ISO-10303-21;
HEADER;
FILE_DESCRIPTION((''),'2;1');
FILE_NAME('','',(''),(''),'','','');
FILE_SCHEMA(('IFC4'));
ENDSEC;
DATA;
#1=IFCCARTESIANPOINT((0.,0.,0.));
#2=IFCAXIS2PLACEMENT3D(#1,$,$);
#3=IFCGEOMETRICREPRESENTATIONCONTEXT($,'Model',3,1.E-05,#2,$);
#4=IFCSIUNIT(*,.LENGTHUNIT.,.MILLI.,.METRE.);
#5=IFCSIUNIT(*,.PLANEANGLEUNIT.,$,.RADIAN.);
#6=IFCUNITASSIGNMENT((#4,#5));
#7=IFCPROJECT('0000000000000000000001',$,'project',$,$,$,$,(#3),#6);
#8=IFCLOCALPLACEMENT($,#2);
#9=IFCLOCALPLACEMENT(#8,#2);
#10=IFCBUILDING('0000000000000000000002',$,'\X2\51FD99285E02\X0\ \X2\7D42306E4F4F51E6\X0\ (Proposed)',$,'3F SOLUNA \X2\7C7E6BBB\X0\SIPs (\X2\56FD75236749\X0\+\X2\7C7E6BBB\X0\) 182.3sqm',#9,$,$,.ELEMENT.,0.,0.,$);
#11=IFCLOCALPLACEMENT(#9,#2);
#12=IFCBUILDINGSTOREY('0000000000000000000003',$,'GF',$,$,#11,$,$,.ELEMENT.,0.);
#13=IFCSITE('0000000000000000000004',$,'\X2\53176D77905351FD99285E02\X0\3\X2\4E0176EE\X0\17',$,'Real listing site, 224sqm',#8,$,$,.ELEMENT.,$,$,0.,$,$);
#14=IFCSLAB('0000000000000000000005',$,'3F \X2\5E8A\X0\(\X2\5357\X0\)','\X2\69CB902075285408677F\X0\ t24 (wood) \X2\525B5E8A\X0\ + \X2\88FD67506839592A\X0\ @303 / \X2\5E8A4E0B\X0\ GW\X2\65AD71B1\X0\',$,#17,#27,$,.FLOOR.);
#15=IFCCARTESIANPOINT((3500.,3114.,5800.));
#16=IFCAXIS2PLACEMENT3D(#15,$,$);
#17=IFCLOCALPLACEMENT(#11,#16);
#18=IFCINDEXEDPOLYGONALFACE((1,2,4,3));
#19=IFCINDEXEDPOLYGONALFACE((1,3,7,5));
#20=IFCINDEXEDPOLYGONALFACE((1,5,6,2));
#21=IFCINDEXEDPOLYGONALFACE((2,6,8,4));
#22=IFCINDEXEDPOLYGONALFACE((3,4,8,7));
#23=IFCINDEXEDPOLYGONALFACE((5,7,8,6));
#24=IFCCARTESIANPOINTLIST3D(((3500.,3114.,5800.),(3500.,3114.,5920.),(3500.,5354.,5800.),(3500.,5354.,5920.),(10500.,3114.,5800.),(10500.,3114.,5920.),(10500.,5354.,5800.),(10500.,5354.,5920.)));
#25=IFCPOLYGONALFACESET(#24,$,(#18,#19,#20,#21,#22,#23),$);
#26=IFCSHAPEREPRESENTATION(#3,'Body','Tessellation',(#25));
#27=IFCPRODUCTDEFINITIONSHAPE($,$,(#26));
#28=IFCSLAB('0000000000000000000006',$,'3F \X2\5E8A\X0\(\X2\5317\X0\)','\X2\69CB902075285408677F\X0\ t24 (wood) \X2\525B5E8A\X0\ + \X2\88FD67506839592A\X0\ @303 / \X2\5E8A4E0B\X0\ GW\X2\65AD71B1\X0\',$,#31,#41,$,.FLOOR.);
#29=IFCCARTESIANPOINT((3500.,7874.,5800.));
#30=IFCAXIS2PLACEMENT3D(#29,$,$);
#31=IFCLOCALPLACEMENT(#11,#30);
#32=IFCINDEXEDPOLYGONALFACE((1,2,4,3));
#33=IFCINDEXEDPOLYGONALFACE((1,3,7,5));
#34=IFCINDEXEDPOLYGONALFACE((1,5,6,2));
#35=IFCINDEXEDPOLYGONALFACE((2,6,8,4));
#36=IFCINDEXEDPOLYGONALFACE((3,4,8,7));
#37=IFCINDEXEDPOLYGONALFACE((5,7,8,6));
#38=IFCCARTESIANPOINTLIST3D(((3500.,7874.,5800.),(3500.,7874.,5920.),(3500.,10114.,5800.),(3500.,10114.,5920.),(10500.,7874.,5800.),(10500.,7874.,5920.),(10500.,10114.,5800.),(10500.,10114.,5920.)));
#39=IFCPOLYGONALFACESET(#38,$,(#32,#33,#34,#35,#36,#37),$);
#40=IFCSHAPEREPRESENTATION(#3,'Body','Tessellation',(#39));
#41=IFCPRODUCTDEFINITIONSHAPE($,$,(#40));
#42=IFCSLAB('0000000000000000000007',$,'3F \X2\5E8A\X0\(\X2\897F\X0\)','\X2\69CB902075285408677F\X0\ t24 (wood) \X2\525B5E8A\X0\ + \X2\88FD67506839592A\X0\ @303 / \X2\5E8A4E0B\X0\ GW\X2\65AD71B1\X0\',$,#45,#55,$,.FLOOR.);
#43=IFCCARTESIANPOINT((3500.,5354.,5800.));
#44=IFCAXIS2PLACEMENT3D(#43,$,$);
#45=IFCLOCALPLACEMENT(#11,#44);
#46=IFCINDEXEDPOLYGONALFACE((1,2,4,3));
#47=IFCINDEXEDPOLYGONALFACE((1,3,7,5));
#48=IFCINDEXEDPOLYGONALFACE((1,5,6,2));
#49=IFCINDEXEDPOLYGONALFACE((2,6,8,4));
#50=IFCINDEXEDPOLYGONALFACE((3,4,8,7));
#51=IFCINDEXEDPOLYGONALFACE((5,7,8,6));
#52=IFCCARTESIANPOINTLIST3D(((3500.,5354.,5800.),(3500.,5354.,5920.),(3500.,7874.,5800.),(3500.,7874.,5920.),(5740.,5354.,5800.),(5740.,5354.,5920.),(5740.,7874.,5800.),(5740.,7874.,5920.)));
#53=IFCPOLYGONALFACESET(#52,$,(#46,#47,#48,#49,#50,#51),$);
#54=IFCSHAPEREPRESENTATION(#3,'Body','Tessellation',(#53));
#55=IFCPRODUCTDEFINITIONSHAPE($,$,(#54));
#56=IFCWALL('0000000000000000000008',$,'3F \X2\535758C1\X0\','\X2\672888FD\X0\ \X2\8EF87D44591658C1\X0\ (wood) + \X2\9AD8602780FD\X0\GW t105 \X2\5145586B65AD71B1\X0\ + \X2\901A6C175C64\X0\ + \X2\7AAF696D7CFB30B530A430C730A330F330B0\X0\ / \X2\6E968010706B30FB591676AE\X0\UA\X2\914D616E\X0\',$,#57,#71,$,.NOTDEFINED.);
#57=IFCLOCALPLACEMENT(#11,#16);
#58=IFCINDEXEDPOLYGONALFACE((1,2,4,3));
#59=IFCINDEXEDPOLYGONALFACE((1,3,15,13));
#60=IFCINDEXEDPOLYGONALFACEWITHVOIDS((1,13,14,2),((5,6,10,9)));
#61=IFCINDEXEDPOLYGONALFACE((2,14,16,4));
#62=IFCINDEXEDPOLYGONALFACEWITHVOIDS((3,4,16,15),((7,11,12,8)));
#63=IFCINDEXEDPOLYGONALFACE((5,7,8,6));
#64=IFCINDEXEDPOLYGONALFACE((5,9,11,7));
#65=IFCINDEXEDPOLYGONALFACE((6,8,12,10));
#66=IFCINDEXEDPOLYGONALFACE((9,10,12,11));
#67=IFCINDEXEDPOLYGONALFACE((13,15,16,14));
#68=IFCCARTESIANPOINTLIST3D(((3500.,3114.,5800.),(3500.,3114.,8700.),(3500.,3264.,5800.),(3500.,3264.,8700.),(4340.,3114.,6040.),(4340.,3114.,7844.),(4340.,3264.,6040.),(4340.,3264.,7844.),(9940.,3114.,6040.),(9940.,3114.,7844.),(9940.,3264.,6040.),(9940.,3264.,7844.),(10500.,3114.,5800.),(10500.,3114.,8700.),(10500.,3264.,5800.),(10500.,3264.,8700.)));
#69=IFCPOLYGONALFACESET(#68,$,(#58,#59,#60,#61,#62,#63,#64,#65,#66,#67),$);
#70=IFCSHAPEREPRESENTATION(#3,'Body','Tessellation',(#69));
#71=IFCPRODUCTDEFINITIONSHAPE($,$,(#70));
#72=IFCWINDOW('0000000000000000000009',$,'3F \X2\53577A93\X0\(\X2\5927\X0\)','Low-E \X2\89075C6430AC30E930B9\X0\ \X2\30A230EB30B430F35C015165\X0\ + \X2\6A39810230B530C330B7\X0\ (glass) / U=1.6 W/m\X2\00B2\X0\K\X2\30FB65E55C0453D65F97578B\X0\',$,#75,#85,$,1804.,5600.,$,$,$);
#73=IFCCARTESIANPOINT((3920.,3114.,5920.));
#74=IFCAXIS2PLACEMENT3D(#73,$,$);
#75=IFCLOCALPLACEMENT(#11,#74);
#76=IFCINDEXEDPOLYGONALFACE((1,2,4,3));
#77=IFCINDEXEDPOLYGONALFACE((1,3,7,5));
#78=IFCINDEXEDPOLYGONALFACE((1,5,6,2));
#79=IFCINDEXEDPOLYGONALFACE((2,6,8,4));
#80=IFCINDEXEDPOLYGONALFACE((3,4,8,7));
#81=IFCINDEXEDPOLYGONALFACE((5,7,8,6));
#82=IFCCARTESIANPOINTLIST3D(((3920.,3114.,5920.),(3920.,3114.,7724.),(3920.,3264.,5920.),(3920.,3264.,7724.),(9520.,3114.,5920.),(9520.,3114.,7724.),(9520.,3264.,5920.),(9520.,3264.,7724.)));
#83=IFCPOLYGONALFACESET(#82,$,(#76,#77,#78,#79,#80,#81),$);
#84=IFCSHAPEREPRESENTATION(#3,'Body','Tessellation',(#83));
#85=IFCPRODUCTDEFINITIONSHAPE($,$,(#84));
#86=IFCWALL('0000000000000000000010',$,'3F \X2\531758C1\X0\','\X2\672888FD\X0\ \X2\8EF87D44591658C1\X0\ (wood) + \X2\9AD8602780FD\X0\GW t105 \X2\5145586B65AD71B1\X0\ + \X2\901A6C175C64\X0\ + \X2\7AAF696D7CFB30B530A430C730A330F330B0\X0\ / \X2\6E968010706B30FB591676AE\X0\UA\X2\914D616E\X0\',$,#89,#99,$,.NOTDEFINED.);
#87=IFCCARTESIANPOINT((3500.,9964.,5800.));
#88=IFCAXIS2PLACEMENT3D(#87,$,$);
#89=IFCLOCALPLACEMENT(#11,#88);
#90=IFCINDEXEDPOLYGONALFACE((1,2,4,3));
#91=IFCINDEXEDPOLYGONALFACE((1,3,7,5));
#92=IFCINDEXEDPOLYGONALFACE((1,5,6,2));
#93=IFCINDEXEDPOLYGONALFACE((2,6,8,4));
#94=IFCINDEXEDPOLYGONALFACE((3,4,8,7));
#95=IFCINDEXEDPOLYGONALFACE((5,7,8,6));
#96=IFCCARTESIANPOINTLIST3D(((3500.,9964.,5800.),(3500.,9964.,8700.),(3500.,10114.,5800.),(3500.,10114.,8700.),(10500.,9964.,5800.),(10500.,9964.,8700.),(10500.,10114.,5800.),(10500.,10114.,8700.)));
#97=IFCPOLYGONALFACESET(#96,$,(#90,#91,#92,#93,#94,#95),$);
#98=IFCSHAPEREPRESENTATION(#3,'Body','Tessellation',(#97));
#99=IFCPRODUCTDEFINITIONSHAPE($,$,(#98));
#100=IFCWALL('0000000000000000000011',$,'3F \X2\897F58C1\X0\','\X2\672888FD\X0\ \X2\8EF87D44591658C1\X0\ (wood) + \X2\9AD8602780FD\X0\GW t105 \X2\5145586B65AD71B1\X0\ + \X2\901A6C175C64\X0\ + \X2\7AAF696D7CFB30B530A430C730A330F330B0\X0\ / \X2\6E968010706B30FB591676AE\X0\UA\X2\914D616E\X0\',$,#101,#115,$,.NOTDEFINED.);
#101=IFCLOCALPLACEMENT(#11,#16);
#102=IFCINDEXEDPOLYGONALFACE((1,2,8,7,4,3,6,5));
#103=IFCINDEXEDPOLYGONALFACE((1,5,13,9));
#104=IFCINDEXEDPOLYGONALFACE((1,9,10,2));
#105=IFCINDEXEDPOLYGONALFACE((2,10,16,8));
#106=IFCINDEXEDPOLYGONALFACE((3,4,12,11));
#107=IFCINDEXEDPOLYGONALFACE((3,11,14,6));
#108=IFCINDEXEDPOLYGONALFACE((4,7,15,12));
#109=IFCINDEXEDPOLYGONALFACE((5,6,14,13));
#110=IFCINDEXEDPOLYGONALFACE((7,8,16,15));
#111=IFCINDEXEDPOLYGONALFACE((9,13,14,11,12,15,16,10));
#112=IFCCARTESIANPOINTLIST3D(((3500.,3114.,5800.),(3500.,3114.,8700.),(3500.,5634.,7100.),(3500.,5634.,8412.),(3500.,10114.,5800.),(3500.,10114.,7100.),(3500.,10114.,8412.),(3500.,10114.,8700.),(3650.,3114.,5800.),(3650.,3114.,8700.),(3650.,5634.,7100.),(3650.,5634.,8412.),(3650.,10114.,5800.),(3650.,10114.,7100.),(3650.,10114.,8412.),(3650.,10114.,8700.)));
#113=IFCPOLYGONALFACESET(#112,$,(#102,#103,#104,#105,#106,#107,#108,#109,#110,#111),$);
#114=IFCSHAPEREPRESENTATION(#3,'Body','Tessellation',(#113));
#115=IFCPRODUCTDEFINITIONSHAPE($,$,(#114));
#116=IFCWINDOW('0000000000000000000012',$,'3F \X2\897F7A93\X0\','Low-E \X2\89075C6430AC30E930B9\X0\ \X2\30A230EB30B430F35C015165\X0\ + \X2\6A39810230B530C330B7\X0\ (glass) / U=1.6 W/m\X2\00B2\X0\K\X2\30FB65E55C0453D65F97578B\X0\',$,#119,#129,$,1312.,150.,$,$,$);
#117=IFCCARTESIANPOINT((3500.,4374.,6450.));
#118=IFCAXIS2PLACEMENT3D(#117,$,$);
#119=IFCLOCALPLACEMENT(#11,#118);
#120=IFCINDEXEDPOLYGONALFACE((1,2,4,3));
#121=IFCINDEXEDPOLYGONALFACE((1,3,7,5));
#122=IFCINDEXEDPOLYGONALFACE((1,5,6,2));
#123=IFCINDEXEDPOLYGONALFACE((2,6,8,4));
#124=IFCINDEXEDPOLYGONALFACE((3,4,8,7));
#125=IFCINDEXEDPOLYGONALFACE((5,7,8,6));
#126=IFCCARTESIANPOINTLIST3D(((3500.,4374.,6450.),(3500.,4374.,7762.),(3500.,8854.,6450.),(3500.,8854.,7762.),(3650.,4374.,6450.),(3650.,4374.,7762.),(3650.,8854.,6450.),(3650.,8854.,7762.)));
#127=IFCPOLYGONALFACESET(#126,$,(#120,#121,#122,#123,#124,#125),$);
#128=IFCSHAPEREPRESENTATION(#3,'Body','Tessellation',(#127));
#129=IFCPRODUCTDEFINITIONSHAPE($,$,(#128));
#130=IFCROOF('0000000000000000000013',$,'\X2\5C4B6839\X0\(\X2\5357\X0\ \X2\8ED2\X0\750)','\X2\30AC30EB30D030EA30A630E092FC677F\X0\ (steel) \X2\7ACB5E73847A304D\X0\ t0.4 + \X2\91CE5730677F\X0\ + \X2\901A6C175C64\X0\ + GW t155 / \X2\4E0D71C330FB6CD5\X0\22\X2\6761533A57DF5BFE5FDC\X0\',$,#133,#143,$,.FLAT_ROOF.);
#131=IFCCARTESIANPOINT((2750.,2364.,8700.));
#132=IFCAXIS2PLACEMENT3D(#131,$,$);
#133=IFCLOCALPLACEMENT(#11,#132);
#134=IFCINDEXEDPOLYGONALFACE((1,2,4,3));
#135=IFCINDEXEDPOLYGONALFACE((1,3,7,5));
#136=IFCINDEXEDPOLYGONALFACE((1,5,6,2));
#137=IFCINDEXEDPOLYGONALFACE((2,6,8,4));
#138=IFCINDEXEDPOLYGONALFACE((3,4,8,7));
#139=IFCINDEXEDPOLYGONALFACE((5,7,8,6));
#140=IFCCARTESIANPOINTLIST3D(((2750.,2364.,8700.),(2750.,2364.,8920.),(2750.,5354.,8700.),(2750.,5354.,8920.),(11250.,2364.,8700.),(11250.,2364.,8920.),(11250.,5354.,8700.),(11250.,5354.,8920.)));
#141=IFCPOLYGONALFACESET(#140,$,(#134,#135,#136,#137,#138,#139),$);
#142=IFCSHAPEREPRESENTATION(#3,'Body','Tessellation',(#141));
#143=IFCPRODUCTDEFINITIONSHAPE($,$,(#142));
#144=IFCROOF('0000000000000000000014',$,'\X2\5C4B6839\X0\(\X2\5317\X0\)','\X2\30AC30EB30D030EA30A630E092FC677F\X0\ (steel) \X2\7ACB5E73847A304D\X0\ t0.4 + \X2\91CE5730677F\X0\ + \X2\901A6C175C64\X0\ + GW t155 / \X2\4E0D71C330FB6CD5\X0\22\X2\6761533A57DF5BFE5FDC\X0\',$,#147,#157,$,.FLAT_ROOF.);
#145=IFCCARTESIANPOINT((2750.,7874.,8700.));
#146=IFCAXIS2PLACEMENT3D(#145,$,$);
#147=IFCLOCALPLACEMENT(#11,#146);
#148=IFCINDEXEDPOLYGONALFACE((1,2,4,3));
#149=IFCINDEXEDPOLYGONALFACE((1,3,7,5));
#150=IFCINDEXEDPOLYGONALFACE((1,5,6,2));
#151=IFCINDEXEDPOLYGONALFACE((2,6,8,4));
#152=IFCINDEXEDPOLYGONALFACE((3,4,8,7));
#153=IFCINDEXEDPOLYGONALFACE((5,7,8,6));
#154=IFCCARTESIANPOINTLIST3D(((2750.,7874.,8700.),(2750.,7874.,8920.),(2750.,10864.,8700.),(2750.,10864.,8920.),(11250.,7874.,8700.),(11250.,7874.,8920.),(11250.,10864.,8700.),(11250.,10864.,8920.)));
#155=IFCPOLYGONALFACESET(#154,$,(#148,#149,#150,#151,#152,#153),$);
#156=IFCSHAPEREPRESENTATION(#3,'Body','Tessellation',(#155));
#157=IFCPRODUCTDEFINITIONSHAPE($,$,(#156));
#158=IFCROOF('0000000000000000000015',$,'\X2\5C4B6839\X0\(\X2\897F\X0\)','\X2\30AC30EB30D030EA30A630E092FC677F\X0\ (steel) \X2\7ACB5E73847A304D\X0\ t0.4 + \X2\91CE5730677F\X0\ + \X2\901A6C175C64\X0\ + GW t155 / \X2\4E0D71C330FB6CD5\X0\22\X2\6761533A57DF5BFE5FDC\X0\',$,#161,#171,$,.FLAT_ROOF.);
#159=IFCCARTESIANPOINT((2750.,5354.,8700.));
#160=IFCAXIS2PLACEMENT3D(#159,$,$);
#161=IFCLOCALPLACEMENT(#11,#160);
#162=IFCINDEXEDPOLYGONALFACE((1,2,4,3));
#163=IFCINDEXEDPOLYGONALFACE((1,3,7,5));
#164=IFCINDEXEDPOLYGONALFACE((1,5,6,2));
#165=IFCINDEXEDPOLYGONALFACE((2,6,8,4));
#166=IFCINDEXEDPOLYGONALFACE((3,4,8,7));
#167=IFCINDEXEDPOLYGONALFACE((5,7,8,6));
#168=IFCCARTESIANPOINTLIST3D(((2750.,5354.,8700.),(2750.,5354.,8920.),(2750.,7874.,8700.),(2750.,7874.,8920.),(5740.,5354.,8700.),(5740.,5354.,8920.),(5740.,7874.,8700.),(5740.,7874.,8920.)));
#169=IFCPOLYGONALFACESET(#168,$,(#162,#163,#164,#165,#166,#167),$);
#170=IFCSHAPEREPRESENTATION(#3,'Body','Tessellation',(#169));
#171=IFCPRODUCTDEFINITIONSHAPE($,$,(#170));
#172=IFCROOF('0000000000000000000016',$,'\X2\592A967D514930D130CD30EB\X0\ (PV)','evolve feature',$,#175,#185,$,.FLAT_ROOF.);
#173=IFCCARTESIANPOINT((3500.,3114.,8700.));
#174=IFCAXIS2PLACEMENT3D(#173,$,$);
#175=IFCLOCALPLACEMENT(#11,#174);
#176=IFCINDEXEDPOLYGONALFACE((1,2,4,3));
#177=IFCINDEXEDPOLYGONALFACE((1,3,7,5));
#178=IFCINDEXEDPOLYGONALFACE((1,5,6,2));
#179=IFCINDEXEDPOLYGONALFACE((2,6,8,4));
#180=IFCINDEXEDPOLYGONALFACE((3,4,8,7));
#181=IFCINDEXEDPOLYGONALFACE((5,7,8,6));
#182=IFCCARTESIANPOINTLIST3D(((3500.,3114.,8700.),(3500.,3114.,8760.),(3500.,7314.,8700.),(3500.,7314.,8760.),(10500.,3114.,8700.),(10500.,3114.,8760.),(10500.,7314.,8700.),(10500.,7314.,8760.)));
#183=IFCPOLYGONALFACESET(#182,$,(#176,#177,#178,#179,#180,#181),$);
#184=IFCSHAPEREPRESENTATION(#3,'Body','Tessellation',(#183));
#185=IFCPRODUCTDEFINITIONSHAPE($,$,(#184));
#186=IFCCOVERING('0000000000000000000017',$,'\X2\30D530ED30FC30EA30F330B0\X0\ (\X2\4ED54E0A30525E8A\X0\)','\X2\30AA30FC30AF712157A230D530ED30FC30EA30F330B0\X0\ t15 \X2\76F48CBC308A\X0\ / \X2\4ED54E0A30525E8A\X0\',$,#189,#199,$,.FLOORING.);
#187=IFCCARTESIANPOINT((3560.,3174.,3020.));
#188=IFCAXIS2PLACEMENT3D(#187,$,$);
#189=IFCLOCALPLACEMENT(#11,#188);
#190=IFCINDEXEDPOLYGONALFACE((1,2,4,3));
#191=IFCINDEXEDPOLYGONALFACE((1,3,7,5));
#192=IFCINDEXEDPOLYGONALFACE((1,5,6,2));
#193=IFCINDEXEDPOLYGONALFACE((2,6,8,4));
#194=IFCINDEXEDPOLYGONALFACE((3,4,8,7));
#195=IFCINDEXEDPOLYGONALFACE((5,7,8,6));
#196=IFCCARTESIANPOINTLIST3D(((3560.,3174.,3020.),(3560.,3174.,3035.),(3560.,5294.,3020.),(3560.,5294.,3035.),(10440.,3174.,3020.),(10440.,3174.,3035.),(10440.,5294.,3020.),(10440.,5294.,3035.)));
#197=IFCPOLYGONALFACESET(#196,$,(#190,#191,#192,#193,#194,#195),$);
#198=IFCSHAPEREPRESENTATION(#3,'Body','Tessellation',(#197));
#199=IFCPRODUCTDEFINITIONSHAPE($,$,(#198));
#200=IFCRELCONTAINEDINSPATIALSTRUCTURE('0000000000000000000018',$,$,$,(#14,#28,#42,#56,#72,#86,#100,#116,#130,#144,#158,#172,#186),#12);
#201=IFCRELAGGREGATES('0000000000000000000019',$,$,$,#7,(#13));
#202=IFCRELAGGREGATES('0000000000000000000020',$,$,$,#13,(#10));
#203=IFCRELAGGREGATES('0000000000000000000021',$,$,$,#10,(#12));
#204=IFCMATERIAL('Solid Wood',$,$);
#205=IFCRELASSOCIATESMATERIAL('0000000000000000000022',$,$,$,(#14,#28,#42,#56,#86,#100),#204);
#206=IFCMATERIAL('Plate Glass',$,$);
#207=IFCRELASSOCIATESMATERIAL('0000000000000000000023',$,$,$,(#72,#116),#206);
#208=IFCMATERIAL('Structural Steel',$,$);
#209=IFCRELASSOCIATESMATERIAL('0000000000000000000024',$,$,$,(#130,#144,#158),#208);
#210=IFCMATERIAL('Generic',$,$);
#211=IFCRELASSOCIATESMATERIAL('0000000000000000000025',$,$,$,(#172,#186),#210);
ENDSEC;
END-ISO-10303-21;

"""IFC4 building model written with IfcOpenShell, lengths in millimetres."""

from ifc_helpers import new_model, si_unit, frame, frame_2d, origin, place, context, project, spatial, rectangle, extrude, material, element, fill, save


model = new_model("IFC4")

# Units and contexts
model_context = context("Model", 3, precision=1e-05, world=origin())
ifc_project = project(units=[si_unit("LENGTHUNIT", "METRE", prefix="MILLI"), si_unit("PLANEANGLEUNIT", "RADIAN")], contexts=[model_context])

# Site, building, storey
site_placement = place(None, origin())
site = spatial("IfcSite", under=ifc_project, at=site_placement, Name="北海道函館市3丁目17", ObjectType="Real listing site, 224sqm", CompositionType="ELEMENT", RefElevation=0.0)
building_placement = place(site_placement, origin())
building = spatial("IfcBuilding", under=site, at=building_placement, Name="函館市 終の住処 (Proposed)", ObjectType="3F SOLUNA 籾殻SIPs (国産杉+籾殻) 182.3sqm", CompositionType="ELEMENT", ElevationOfRefHeight=0.0, ElevationOfTerrain=0.0)
storey_placement = place(building_placement, origin())
storey = spatial("IfcBuildingStorey", under=building, at=storey_placement, Name="GF", CompositionType="ELEMENT", Elevation=0.0)

# Slabs
ifc_material_1 = material(Name="Solid Wood")
slab_1_placement = place(storey_placement, frame((3500.0, 3114.0, 5800.0)))
element("IfcSlab", 1, at=slab_1_placement, inside=storey, material=ifc_material_1, Name="3F 床(南)", Description="構造用合板 t24 (wood) 剛床 + 製材根太 @303 / 床下 GW断熱", PredefinedType="FLOOR", context=model_context, shape_type="SweptSolid", body=[
    extrude(rectangle(XDim=7000.0, YDim=2240.0, at=frame_2d((3500.0, 1120.0))), frame((3500.0, 3114.0, 5800.0)), (0.0, 0.0, 1.0), 120.0),
])
slab_2_placement = place(storey_placement, frame((3500.0, 7874.0, 5800.0)))
element("IfcSlab", 2, at=slab_2_placement, inside=storey, material=ifc_material_1, Name="3F 床(北)", Description="構造用合板 t24 (wood) 剛床 + 製材根太 @303 / 床下 GW断熱", PredefinedType="FLOOR", context=model_context, shape_type="SweptSolid", body=[
    extrude(rectangle(XDim=7000.0, YDim=2240.0, at=frame_2d((3500.0, 1120.0))), frame((3500.0, 7874.0, 5800.0)), (0.0, 0.0, 1.0), 120.0),
])
slab_3_placement = place(storey_placement, frame((3500.0, 5354.0, 5800.0)))
element("IfcSlab", 3, at=slab_3_placement, inside=storey, material=ifc_material_1, Name="3F 床(西)", Description="構造用合板 t24 (wood) 剛床 + 製材根太 @303 / 床下 GW断熱", PredefinedType="FLOOR", context=model_context, shape_type="SweptSolid", body=[
    extrude(rectangle(XDim=2240.0, YDim=2520.0, at=frame_2d((1120.0, 1260.0))), frame((3500.0, 5354.0, 5800.0)), (0.0, 0.0, 1.0), 120.0),
])

# Wall, opening, window
wall_1_placement = place(storey_placement, frame((3500.0, 3114.0, 5800.0)))
wall_1 = element("IfcWall", 4, at=wall_1_placement, inside=storey, material=ifc_material_1, Name="3F 南壁", Description="木製 軸組外壁 (wood) + 高性能GW t105 充填断熱 + 通気層 + 窯業系サイディング / 準耐火・外皮UA配慮", PredefinedType="NOTDEFINED", context=model_context, shape_type="SweptSolid", body=[
    extrude(rectangle(XDim=7000.0, YDim=150.0, at=frame_2d((3500.0, 75.0))), frame((3500.0, 3114.0, 5800.0)), (0.0, 0.0, 1.0), 2900.0),
])
opening_1_placement = place(storey_placement, frame((3920.0, 3114.0, 5920.0)))
opening_1 = element("IfcOpeningElement", 5, at=opening_1_placement, cuts=wall_1, PredefinedType="NOTDEFINED", context=model_context, shape_type="SweptSolid", body=[
    extrude(rectangle(XDim=5600.0, YDim=150.0, at=frame_2d((2800.0, 75.0))), frame((3920.0, 3114.0, 5920.0)), (0.0, 0.0, 1.0), 1804.0),
])
ifc_material_2 = material(Name="Plate Glass")
window_1_placement = place(storey_placement, frame((3920.0, 3114.0, 5920.0)))
window_1 = element("IfcWindow", 6, at=window_1_placement, inside=storey, material=ifc_material_2, Name="3F 南窓(大)", Description="Low-E 複層ガラス アルゴン封入 + 樹脂サッシ (glass) / U=1.6 W/m²K・日射取得型", OverallHeight=1804.0, OverallWidth=5600.0, context=model_context, shape_type="SweptSolid", body=[
    extrude(rectangle(XDim=5600.0, YDim=150.0, at=frame_2d((2800.0, 75.0))), frame((3920.0, 3114.0, 5920.0)), (0.0, 0.0, 1.0), 1804.0),
])
fill(opening_1, window_1)

# Wall
wall_2_placement = place(storey_placement, frame((3500.0, 9964.0, 5800.0)))
element("IfcWall", 7, at=wall_2_placement, inside=storey, material=ifc_material_1, Name="3F 北壁", Description="木製 軸組外壁 (wood) + 高性能GW t105 充填断熱 + 通気層 + 窯業系サイディング / 準耐火・外皮UA配慮", PredefinedType="NOTDEFINED", context=model_context, shape_type="SweptSolid", body=[
    extrude(rectangle(XDim=7000.0, YDim=150.0, at=frame_2d((3500.0, 75.0))), frame((3500.0, 9964.0, 5800.0)), (0.0, 0.0, 1.0), 2900.0),
])

# Wall, opening, window
wall_3_placement = place(storey_placement, frame((3500.0, 3114.0, 5800.0)))
wall_3 = element("IfcWall", 8, at=wall_3_placement, inside=storey, material=ifc_material_1, Name="3F 西壁", Description="木製 軸組外壁 (wood) + 高性能GW t105 充填断熱 + 通気層 + 窯業系サイディング / 準耐火・外皮UA配慮", PredefinedType="NOTDEFINED", context=model_context, shape_type="SweptSolid", body=[
    extrude(rectangle(XDim=150.0, YDim=7000.0, at=frame_2d((75.0, 3500.0))), frame((3500.0, 3114.0, 5800.0)), (0.0, 0.0, 1.0), 2900.0),
])
opening_2_placement = place(storey_placement, frame((3500.0, 4374.0, 6450.0)))
opening_2 = element("IfcOpeningElement", 9, at=opening_2_placement, cuts=wall_3, PredefinedType="NOTDEFINED", context=model_context, shape_type="SweptSolid", body=[
    extrude(rectangle(XDim=150.0, YDim=4480.0, at=frame_2d((75.0, 2240.0))), frame((3500.0, 4374.0, 6450.0)), (0.0, 0.0, 1.0), 1312.0),
])
window_2_placement = place(storey_placement, frame((3500.0, 4374.0, 6450.0)))
window_2 = element("IfcWindow", 10, at=window_2_placement, inside=storey, material=ifc_material_2, Name="3F 西窓", Description="Low-E 複層ガラス アルゴン封入 + 樹脂サッシ (glass) / U=1.6 W/m²K・日射取得型", OverallHeight=1312.0, OverallWidth=150.0, context=model_context, shape_type="SweptSolid", body=[
    extrude(rectangle(XDim=150.0, YDim=4480.0, at=frame_2d((75.0, 2240.0))), frame((3500.0, 4374.0, 6450.0)), (0.0, 0.0, 1.0), 1312.0),
])
fill(opening_2, window_2)

# Roofs
ifc_material_3 = material(Name="Structural Steel")
roof_1_placement = place(storey_placement, frame((2750.0, 2364.0, 8700.0)))
element("IfcRoof", 11, at=roof_1_placement, inside=storey, material=ifc_material_3, Name="屋根(南 軒750)", Description="ガルバリウム鋼板 (steel) 立平葺き t0.4 + 野地板 + 通気層 + GW t155 / 不燃・法22条区域対応", PredefinedType="FLAT_ROOF", context=model_context, shape_type="SweptSolid", body=[
    extrude(rectangle(XDim=8500.0, YDim=2990.0, at=frame_2d((4250.0, 1495.0))), frame((2750.0, 2364.0, 8700.0)), (0.0, 0.0, 1.0), 220.0),
])
roof_2_placement = place(storey_placement, frame((2750.0, 7874.0, 8700.0)))
element("IfcRoof", 12, at=roof_2_placement, inside=storey, material=ifc_material_3, Name="屋根(北)", Description="ガルバリウム鋼板 (steel) 立平葺き t0.4 + 野地板 + 通気層 + GW t155 / 不燃・法22条区域対応", PredefinedType="FLAT_ROOF", context=model_context, shape_type="SweptSolid", body=[
    extrude(rectangle(XDim=8500.0, YDim=2990.0, at=frame_2d((4250.0, 1495.0))), frame((2750.0, 7874.0, 8700.0)), (0.0, 0.0, 1.0), 220.0),
])
roof_3_placement = place(storey_placement, frame((2750.0, 5354.0, 8700.0)))
element("IfcRoof", 13, at=roof_3_placement, inside=storey, material=ifc_material_3, Name="屋根(西)", Description="ガルバリウム鋼板 (steel) 立平葺き t0.4 + 野地板 + 通気層 + GW t155 / 不燃・法22条区域対応", PredefinedType="FLAT_ROOF", context=model_context, shape_type="SweptSolid", body=[
    extrude(rectangle(XDim=2990.0, YDim=2520.0, at=frame_2d((1495.0, 1260.0))), frame((2750.0, 5354.0, 8700.0)), (0.0, 0.0, 1.0), 220.0),
])
ifc_material_4 = material(Name="Generic")
roof_4_placement = place(storey_placement, frame((3500.0, 3114.0, 8700.0)))
element("IfcRoof", 14, at=roof_4_placement, inside=storey, material=ifc_material_4, Name="太陽光パネル (PV)", Description="evolve feature", PredefinedType="FLAT_ROOF", context=model_context, shape_type="SweptSolid", body=[
    extrude(rectangle(XDim=7000.0, YDim=4200.0, at=frame_2d((3500.0, 2100.0))), frame((3500.0, 3114.0, 8700.0)), (0.0, 0.0, 1.0), 60.0),
])

# Covering
covering_1_placement = place(storey_placement, frame((3560.0, 3174.0, 3020.0)))
element("IfcCovering", 15, at=covering_1_placement, inside=storey, material=ifc_material_4, Name="フローリング (仕上げ床)", Description="オーク無垢フローリング t15 直貼り / 仕上げ床", PredefinedType="FLOORING", context=model_context, shape_type="SweptSolid", body=[
    extrude(rectangle(XDim=6880.0, YDim=2120.0, at=frame_2d((3440.0, 1060.0))), frame((3560.0, 3174.0, 3020.0)), (0.0, 0.0, 1.0), 15.0),
])

save(model, "model.ifc")
